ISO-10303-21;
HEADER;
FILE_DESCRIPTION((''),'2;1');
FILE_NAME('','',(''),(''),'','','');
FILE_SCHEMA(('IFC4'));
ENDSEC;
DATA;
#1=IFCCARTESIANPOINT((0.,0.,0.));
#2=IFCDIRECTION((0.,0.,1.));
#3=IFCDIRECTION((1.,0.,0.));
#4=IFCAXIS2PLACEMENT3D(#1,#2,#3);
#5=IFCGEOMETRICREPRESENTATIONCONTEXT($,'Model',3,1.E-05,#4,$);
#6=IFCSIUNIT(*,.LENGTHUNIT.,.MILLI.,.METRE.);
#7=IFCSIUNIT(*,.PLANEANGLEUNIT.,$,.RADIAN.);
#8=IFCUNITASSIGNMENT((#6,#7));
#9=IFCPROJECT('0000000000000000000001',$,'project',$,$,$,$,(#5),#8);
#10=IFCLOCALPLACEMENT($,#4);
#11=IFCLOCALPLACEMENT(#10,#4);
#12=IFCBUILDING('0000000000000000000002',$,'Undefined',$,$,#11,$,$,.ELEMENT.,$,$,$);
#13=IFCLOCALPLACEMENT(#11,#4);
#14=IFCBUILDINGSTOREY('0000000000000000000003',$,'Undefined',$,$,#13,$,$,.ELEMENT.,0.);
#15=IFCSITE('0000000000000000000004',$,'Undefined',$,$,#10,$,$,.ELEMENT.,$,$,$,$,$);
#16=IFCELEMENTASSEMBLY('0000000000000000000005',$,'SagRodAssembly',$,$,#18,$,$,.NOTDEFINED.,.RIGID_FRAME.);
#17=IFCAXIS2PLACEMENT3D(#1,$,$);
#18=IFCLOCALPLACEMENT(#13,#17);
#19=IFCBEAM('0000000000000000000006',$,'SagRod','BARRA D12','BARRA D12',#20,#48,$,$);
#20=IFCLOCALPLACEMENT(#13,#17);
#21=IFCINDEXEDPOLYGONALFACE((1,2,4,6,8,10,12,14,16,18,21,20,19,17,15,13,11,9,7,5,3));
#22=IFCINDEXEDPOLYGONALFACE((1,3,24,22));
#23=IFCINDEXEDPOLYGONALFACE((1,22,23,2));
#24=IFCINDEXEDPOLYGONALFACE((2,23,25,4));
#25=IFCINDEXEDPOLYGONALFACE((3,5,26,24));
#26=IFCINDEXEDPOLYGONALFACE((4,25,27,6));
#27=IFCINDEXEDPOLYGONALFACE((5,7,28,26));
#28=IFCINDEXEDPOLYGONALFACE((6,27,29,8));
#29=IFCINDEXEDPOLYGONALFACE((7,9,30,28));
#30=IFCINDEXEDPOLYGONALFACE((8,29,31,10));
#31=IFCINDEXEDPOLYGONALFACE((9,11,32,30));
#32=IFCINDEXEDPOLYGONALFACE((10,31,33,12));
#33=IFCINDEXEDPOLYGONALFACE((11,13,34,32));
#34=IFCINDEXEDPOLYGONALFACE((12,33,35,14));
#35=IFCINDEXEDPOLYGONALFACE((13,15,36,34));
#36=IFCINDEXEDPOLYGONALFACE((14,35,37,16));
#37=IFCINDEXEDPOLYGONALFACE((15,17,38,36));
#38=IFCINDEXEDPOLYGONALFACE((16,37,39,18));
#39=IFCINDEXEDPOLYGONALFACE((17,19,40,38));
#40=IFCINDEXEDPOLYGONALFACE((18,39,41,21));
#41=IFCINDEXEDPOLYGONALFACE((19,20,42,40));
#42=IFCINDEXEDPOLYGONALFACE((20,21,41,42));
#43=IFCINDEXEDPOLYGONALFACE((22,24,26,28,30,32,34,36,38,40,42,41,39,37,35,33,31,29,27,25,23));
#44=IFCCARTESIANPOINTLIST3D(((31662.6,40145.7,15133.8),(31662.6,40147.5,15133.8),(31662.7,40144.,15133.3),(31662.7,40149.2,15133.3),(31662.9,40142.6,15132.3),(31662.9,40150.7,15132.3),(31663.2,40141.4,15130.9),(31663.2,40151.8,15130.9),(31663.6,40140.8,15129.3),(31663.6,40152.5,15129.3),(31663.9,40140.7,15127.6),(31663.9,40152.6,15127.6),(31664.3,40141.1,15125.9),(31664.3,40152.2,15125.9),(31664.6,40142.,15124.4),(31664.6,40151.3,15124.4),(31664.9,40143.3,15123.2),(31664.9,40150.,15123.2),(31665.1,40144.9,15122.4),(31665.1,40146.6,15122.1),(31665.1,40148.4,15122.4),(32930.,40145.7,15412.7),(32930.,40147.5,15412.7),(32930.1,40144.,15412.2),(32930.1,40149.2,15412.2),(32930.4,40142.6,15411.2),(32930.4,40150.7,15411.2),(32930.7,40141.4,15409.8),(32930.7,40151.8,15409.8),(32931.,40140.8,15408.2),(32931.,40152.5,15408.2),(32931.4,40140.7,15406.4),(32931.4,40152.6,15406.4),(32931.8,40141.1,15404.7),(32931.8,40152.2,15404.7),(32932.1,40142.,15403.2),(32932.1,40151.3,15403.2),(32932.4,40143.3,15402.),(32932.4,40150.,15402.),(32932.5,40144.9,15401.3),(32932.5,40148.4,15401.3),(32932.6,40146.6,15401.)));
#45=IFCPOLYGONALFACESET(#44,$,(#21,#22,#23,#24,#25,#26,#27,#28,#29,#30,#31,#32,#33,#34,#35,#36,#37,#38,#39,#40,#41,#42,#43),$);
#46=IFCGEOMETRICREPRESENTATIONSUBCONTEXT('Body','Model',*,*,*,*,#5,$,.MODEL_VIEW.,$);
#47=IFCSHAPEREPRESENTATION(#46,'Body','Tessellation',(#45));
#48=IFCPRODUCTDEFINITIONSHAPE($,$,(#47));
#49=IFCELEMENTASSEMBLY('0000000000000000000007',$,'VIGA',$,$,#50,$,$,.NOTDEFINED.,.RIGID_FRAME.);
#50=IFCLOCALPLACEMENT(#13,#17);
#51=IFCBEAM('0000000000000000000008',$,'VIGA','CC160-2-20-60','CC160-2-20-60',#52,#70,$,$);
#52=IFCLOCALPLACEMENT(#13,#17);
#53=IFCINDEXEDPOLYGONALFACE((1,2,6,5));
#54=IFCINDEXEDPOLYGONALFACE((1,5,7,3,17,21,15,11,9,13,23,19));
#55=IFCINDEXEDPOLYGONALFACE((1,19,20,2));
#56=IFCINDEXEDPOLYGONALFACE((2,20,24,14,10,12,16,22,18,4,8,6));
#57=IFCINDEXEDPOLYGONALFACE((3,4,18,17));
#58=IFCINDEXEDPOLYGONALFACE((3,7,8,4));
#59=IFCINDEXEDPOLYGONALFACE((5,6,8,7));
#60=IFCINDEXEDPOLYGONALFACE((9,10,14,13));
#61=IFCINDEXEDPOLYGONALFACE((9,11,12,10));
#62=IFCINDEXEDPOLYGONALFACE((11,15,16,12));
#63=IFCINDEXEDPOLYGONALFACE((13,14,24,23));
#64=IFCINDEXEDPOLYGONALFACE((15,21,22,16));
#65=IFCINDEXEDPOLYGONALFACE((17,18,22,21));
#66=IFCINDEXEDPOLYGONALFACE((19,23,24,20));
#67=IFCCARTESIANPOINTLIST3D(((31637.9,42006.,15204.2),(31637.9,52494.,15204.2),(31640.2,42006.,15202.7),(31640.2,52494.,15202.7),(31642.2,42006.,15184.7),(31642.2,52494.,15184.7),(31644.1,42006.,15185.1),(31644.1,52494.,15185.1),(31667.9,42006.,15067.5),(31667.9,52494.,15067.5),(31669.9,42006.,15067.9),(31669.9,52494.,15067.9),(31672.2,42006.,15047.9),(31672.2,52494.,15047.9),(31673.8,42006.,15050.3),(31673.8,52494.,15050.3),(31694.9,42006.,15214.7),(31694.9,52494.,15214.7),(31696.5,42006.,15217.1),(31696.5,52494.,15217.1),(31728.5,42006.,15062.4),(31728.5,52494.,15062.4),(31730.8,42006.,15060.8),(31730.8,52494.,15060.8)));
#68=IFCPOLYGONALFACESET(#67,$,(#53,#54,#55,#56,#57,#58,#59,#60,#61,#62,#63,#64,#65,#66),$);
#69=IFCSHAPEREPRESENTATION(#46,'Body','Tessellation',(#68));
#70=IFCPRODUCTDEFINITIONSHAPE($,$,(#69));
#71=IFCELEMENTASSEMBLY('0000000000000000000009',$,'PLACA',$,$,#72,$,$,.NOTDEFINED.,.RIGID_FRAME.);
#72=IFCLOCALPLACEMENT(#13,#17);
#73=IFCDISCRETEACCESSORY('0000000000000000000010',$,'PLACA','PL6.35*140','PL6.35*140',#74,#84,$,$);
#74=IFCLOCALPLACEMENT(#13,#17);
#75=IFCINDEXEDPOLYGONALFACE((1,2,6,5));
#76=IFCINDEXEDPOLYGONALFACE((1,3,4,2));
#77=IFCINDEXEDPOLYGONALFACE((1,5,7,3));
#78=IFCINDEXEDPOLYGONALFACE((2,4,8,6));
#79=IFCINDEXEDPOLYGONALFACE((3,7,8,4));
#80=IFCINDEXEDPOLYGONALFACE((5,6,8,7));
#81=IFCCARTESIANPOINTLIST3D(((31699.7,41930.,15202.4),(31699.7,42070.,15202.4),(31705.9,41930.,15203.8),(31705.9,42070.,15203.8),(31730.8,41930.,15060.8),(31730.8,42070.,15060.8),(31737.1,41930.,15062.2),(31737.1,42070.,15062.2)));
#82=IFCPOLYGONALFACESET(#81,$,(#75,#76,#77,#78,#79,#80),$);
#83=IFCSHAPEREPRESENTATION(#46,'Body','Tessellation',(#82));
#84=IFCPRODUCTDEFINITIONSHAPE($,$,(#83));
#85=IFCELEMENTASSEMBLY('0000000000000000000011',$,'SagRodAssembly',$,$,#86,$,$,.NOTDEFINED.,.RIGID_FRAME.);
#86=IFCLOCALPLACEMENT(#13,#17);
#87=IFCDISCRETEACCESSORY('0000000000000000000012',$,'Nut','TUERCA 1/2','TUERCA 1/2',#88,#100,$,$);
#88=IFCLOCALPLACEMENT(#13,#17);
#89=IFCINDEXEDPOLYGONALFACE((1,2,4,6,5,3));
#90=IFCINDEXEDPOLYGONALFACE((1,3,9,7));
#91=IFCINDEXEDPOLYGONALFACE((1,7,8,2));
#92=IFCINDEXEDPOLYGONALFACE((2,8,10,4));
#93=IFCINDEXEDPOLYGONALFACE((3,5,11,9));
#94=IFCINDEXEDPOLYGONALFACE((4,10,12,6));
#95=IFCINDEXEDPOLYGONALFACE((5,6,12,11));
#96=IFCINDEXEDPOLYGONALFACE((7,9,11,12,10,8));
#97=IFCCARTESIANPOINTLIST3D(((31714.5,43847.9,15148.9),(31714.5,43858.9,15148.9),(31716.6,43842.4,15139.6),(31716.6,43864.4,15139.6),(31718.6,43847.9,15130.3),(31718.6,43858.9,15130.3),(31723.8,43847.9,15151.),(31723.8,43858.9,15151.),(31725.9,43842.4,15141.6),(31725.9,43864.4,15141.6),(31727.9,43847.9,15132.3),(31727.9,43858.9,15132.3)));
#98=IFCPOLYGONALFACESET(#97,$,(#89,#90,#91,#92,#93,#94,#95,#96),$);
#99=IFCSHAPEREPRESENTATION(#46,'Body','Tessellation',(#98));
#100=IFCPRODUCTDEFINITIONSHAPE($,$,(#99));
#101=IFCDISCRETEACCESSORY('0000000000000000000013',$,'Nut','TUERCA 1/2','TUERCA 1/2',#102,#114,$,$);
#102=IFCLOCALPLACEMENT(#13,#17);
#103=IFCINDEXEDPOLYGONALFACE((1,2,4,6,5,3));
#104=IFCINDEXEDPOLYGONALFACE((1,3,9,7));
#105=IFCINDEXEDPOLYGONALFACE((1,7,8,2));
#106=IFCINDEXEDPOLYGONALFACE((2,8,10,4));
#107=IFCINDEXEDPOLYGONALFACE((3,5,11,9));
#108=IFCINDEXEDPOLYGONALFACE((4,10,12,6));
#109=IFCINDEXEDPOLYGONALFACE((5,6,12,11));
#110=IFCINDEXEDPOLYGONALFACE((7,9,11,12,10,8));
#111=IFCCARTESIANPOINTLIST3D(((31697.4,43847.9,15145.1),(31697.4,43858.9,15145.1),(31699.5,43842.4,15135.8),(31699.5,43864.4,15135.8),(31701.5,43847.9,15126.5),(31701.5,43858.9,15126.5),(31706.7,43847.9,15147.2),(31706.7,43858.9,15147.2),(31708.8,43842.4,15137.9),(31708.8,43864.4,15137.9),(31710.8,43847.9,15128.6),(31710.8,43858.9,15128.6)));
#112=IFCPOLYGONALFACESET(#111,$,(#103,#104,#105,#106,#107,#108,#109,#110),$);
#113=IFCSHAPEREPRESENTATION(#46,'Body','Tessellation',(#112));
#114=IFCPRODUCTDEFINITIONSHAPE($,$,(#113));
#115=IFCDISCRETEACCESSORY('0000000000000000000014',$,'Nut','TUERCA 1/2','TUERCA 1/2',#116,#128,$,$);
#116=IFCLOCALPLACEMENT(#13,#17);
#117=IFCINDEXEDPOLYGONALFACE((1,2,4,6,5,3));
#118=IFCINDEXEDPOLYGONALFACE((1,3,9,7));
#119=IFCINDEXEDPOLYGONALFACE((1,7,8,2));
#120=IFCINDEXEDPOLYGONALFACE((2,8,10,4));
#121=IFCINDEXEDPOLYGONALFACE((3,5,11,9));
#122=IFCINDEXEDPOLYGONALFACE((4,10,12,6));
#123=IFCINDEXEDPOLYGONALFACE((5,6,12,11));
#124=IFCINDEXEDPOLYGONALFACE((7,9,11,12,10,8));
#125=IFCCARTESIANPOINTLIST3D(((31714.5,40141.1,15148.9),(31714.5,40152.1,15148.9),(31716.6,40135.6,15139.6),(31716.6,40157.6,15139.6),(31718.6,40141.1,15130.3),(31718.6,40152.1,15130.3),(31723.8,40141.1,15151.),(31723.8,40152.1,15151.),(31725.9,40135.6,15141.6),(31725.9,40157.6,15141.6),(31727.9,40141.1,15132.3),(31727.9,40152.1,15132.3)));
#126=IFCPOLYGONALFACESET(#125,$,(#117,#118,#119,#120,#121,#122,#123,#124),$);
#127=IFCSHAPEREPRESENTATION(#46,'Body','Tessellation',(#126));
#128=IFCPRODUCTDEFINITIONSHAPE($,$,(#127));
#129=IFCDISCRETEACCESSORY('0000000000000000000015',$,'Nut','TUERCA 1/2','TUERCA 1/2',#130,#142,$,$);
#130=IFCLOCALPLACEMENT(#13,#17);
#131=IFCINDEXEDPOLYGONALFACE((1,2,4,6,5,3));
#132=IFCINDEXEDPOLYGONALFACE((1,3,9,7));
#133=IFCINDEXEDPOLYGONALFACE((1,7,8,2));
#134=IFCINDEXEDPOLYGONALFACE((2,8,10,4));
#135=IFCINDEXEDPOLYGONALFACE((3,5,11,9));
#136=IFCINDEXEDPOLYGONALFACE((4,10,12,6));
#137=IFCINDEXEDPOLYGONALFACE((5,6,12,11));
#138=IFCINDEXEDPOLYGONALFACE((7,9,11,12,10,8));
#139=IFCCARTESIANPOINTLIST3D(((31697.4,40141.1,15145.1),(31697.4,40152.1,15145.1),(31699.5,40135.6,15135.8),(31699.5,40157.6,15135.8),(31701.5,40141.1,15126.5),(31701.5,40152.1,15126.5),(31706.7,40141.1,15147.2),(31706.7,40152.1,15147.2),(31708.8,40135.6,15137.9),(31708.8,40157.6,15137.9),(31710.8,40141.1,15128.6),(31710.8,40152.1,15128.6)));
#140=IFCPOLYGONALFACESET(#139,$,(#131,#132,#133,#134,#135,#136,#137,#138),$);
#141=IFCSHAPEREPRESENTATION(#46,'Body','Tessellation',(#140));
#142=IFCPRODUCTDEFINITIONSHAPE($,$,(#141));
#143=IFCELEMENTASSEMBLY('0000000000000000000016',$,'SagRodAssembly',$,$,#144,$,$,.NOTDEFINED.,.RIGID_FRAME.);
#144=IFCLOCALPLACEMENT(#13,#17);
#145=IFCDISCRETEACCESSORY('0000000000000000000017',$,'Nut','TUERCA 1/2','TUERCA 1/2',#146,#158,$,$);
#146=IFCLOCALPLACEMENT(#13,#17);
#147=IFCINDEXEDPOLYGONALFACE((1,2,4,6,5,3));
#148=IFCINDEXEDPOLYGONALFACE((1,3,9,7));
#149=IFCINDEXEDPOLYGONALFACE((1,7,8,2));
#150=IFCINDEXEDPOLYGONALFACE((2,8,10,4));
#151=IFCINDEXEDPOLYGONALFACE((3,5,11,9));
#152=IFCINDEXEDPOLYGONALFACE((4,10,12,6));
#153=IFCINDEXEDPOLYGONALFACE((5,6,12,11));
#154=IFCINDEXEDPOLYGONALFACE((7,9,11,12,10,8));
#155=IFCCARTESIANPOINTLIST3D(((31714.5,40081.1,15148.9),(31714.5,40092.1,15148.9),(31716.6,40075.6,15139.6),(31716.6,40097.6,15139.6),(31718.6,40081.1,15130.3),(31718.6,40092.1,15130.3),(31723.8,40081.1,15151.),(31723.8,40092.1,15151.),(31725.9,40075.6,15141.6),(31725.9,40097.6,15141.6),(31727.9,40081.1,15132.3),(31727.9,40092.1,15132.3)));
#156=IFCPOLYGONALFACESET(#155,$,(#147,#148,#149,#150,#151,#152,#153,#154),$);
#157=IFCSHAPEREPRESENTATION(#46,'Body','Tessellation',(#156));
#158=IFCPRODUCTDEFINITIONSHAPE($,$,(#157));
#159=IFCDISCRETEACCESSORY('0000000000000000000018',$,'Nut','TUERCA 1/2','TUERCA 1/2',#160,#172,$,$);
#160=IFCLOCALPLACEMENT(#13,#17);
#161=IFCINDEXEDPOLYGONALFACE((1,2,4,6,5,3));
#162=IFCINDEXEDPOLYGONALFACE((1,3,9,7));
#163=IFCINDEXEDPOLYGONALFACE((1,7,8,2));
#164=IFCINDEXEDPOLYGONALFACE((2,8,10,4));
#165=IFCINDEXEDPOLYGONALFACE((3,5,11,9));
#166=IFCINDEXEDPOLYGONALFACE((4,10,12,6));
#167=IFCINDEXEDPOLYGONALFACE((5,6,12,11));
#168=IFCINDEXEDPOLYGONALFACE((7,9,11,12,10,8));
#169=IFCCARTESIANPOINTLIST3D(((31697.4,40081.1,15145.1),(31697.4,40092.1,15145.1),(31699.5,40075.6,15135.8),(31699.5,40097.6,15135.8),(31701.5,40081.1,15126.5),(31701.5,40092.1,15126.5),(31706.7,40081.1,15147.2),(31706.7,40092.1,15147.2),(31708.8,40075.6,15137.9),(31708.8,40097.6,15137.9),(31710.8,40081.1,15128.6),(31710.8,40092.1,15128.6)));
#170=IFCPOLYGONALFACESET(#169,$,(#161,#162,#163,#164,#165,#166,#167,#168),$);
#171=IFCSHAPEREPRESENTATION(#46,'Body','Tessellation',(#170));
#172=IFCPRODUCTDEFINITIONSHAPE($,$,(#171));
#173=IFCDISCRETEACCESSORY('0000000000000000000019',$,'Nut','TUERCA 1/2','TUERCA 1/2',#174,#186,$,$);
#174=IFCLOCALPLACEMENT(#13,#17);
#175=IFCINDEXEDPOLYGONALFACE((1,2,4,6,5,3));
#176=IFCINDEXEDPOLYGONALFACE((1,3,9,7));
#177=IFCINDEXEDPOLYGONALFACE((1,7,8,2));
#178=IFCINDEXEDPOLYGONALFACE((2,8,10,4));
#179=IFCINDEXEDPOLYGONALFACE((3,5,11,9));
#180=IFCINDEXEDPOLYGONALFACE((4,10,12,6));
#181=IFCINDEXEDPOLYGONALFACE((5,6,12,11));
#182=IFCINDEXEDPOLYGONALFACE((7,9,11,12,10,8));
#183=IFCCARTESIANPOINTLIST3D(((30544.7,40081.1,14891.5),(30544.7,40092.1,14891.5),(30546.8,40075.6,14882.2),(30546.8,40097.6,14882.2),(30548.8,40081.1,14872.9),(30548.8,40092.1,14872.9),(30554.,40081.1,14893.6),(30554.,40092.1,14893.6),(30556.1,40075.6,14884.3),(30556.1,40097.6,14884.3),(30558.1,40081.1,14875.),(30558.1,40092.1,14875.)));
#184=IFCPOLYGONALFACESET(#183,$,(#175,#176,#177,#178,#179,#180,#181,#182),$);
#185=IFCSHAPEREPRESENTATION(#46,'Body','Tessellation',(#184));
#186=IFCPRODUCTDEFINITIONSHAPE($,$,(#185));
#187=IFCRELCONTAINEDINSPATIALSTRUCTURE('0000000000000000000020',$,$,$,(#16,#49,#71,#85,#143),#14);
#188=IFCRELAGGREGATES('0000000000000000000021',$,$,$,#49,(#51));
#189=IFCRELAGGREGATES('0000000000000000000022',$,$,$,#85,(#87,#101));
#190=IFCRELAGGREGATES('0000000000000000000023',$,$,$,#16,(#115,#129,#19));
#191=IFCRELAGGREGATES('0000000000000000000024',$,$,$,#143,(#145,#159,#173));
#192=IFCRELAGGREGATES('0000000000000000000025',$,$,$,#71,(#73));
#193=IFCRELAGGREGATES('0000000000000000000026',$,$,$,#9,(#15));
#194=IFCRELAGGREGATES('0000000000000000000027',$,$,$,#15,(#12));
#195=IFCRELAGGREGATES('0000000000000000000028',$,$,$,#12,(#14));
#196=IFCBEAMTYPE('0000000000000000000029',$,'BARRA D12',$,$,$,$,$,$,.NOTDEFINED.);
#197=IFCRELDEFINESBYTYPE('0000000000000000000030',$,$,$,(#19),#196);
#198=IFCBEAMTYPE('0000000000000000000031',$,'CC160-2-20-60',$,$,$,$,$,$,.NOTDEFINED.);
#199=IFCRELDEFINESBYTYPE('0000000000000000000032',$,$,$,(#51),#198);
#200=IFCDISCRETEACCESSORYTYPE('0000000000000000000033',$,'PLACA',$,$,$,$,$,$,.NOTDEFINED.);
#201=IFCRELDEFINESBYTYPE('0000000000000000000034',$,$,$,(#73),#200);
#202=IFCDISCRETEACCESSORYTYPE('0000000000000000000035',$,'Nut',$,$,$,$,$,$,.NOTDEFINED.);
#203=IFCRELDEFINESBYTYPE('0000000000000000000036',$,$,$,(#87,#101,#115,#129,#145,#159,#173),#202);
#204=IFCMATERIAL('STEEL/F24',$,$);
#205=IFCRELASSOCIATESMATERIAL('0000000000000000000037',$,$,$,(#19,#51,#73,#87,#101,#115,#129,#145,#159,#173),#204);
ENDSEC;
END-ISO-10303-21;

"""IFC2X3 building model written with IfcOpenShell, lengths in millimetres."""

from ifc_helpers import new_model, si_unit, frame, origin_with_axes, origin_2d_with_axis, place, context, subcontext, project, spatial, polyline, circle, c_section, outline, extrude, clip, halfspace, material, type_object, element, aggregate, save


model = new_model("IFC2X3")

# Units and contexts
model_context = context("Model", 3, precision=1e-05, world=origin_with_axes())
body_context = subcontext(model_context, "Body", "Model", "MODEL_VIEW")
ifc_project = project(units=[si_unit("LENGTHUNIT", "METRE", prefix="MILLI"), si_unit("PLANEANGLEUNIT", "RADIAN")], contexts=[model_context])

# Site, building, storey
site_placement = place(None, origin_with_axes())
site = spatial("IfcSite", under=ifc_project, at=site_placement, Name="Undefined", CompositionType="ELEMENT")
building_placement = place(site_placement, origin_with_axes())
building = spatial("IfcBuilding", under=site, at=building_placement, Name="Undefined", CompositionType="ELEMENT")
storey_placement = place(building_placement, origin_with_axes())
storey = spatial("IfcBuildingStorey", under=building, at=storey_placement, Name="Undefined", CompositionType="ELEMENT", Elevation=0.0)

# Element assemblies, beams
assembly_1_placement = place(storey_placement, origin_with_axes())
assembly_1 = element("IfcElementAssembly", 1, at=assembly_1_placement, inside=storey, Name="SagRodAssembly", AssemblyPlace="NOTDEFINED", PredefinedType="RIGID_FRAME")
ifc_material_1 = material(Name="STEEL/F24")
beam_type_1 = type_object("IfcBeamType", Name="BARRA D12", PredefinedType="NOTDEFINED")
beam_1_placement = place(assembly_1_placement, frame((31663.8, 40146.6, 15128.0), z_axis=(0.0, -1.0, 0.0), x_axis=(0.976639, 0.0, 0.214887)))
beam_1 = element("IfcBeam", 2, at=beam_1_placement, type_object=beam_type_1, material=ifc_material_1, Name="SagRod", Description="BARRA D12", ObjectType="BARRA D12", context=body_context, shape_type="SweptSolid", body=[
    extrude(circle(Radius=6.0, at=origin_2d_with_axis()), frame((1297.8, 0.0, 0.0), z_axis=(-1.0, 0.0, 0.0), x_axis=(0.0, -1.0, 0.0)), (0.0, 0.0, 1.0), 1297.8),
])
assembly_2_placement = place(storey_placement, origin_with_axes())
assembly_2 = element("IfcElementAssembly", 3, at=assembly_2_placement, inside=storey, Name="VIGA", AssemblyPlace="NOTDEFINED", PredefinedType="RIGID_FRAME")
beam_type_2 = type_object("IfcBeamType", Name="CC160-2-20-60", PredefinedType="NOTDEFINED")
beam_2_placement = place(assembly_2_placement, frame((31684.4, 42000.0, 15132.5), z_axis=(0.214887, 0.0, -0.976639), x_axis=(0.0, 1.0, 0.0)))
beam_2 = element("IfcBeam", 4, at=beam_2_placement, type_object=beam_type_2, material=ifc_material_1, Name="VIGA", Description="CC160-2-20-60", ObjectType="CC160-2-20-60", context=body_context, shape_type="Clipping", body=[
    clip(clip(extrude(c_section(Depth=160.0, Width=60.0, WallThickness=2.0, Girth=20.0, at=origin_2d_with_axis()), frame((10500.0, 0.0, 0.0), z_axis=(-1.0, 0.0, 0.0), x_axis=(0.0, -1.0, 0.0)), (0.0, 0.0, 1.0), 10500.0), halfspace(frame((10494.0, -30.0, -80.0), z_axis=(1.0, 0.0, 0.000029), x_axis=(-0.000029, 0.0, 1.0)), False)), halfspace(frame((6.0, 30.0, -80.0), z_axis=(-1.0, 0.0, -0.000029), x_axis=(-0.000029, 0.0, 1.0)), False)),
])
aggregate(assembly_2, [beam_2])

# Element assembly, discrete accessory
assembly_3_placement = place(storey_placement, origin_with_axes())
assembly_3 = element("IfcElementAssembly", 5, at=assembly_3_placement, inside=storey, Name="PLACA", AssemblyPlace="NOTDEFINED", PredefinedType="RIGID_FRAME")
discrete_accessory_type_1 = type_object("IfcDiscreteAccessoryType", Name="PLACA")
discrete_accessory_1_placement = place(assembly_3_placement, frame((31702.8, 41930.0, 15203.1), z_axis=(-0.976639, 0.0, -0.214887), x_axis=(0.0, 1.0, 0.0)))
discrete_accessory_1 = element("IfcDiscreteAccessory", 6, at=discrete_accessory_1_placement, type_object=discrete_accessory_type_1, material=ifc_material_1, Name="PLACA", Description="PL6.35*140", ObjectType="PL6.35*140", context=body_context, shape_type="SweptSolid", body=[
    extrude(outline(polyline([(0.0, 0.0), (140.0, 0.0), (140.0, 145.0), (0.0, 145.0), (0.0, 0.0)])), frame((0.0, 0.0, -3.2), z_axis=(0.0, 0.0, 1.0), x_axis=(1.0, 0.0, 0.0)), (0.0, 0.0, 1.0), 6.4),
])

# Element assembly, discrete accessories
assembly_4_placement = place(storey_placement, origin_with_axes())
assembly_4 = element("IfcElementAssembly", 7, at=assembly_4_placement, inside=storey, Name="SagRodAssembly", AssemblyPlace="NOTDEFINED", PredefinedType="RIGID_FRAME")
discrete_accessory_type_2 = type_object("IfcDiscreteAccessoryType", Name="Nut")
discrete_accessory_2_placement = place(assembly_4_placement, frame((31716.6, 43853.4, 15139.6), z_axis=(-0.214887, 0.0, 0.976639), x_axis=(0.976639, 0.0, 0.214887)))
discrete_accessory_2 = element("IfcDiscreteAccessory", 8, at=discrete_accessory_2_placement, type_object=discrete_accessory_type_2, material=ifc_material_1, Name="Nut", Description="TUERCA 1/2", ObjectType="TUERCA 1/2", context=body_context, shape_type="SweptSolid", body=[
    extrude(outline(polyline([(-5.5, 9.5), (5.5, 9.5), (11.0, 0.0), (5.5, -9.5), (-5.5, -9.5), (-11.0, 0.0), (-5.5, 9.5)])), frame((9.5, 0.0, 0.0), z_axis=(-1.0, 0.0, 0.0), x_axis=(0.0, -1.0, 0.0)), (0.0, 0.0, 1.0), 9.5),
])
discrete_accessory_3_placement = place(assembly_4_placement, frame((31699.5, 43853.4, 15135.8), z_axis=(-0.214887, 0.0, 0.976639), x_axis=(0.976639, 0.0, 0.214887)))
discrete_accessory_3 = element("IfcDiscreteAccessory", 9, at=discrete_accessory_3_placement, type_object=discrete_accessory_type_2, material=ifc_material_1, Name="Nut", Description="TUERCA 1/2", ObjectType="TUERCA 1/2", context=body_context, shape_type="SweptSolid", body=[
    extrude(outline(polyline([(-5.5, 9.5), (5.5, 9.5), (11.0, 0.0), (5.5, -9.5), (-5.5, -9.5), (-11.0, 0.0), (-5.5, 9.5)])), frame((9.5, 0.0, 0.0), z_axis=(-1.0, 0.0, 0.0), x_axis=(0.0, -1.0, 0.0)), (0.0, 0.0, 1.0), 9.5),
])

# Discrete accessories
discrete_accessory_4_placement = place(assembly_1_placement, frame((31716.6, 40146.6, 15139.6), z_axis=(-0.214887, 0.0, 0.976639), x_axis=(0.976639, 0.0, 0.214887)))
discrete_accessory_4 = element("IfcDiscreteAccessory", 10, at=discrete_accessory_4_placement, type_object=discrete_accessory_type_2, material=ifc_material_1, Name="Nut", Description="TUERCA 1/2", ObjectType="TUERCA 1/2", context=body_context, shape_type="SweptSolid", body=[
    extrude(outline(polyline([(-5.5, 9.5), (5.5, 9.5), (11.0, 0.0), (5.5, -9.5), (-5.5, -9.5), (-11.0, 0.0), (-5.5, 9.5)])), frame((9.5, 0.0, 0.0), z_axis=(-1.0, 0.0, 0.0), x_axis=(0.0, -1.0, 0.0)), (0.0, 0.0, 1.0), 9.5),
])
discrete_accessory_5_placement = place(assembly_1_placement, frame((31699.5, 40146.6, 15135.8), z_axis=(-0.214887, 0.0, 0.976639), x_axis=(0.976639, 0.0, 0.214887)))
discrete_accessory_5 = element("IfcDiscreteAccessory", 11, at=discrete_accessory_5_placement, type_object=discrete_accessory_type_2, material=ifc_material_1, Name="Nut", Description="TUERCA 1/2", ObjectType="TUERCA 1/2", context=body_context, shape_type="SweptSolid", body=[
    extrude(outline(polyline([(-5.5, 9.5), (5.5, 9.5), (11.0, 0.0), (5.5, -9.5), (-5.5, -9.5), (-11.0, 0.0), (-5.5, 9.5)])), frame((9.5, 0.0, 0.0), z_axis=(-1.0, 0.0, 0.0), x_axis=(0.0, -1.0, 0.0)), (0.0, 0.0, 1.0), 9.5),
])

# Element assembly, discrete accessories
assembly_5_placement = place(storey_placement, origin_with_axes())
assembly_5 = element("IfcElementAssembly", 12, at=assembly_5_placement, inside=storey, Name="SagRodAssembly", AssemblyPlace="NOTDEFINED", PredefinedType="RIGID_FRAME")
discrete_accessory_6_placement = place(assembly_5_placement, frame((31716.6, 40086.6, 15139.6), z_axis=(-0.214887, 0.0, 0.976639), x_axis=(0.976639, 0.0, 0.214887)))
discrete_accessory_6 = element("IfcDiscreteAccessory", 13, at=discrete_accessory_6_placement, type_object=discrete_accessory_type_2, material=ifc_material_1, Name="Nut", Description="TUERCA 1/2", ObjectType="TUERCA 1/2", context=body_context, shape_type="SweptSolid", body=[
    extrude(outline(polyline([(-5.5, 9.5), (5.5, 9.5), (11.0, 0.0), (5.5, -9.5), (-5.5, -9.5), (-11.0, 0.0), (-5.5, 9.5)])), frame((9.5, 0.0, 0.0), z_axis=(-1.0, 0.0, 0.0), x_axis=(0.0, -1.0, 0.0)), (0.0, 0.0, 1.0), 9.5),
])
discrete_accessory_7_placement = place(assembly_5_placement, frame((31699.5, 40086.6, 15135.8), z_axis=(-0.214887, 0.0, 0.976639), x_axis=(0.976639, 0.0, 0.214887)))
discrete_accessory_7 = element("IfcDiscreteAccessory", 14, at=discrete_accessory_7_placement, type_object=discrete_accessory_type_2, material=ifc_material_1, Name="Nut", Description="TUERCA 1/2", ObjectType="TUERCA 1/2", context=body_context, shape_type="SweptSolid", body=[
    extrude(outline(polyline([(-5.5, 9.5), (5.5, 9.5), (11.0, 0.0), (5.5, -9.5), (-5.5, -9.5), (-11.0, 0.0), (-5.5, 9.5)])), frame((9.5, 0.0, 0.0), z_axis=(-1.0, 0.0, 0.0), x_axis=(0.0, -1.0, 0.0)), (0.0, 0.0, 1.0), 9.5),
])
discrete_accessory_8_placement = place(assembly_5_placement, frame((30546.8, 40086.6, 14882.2), z_axis=(-0.214887, 0.0, 0.976639), x_axis=(0.976639, 0.0, 0.214887)))
discrete_accessory_8 = element("IfcDiscreteAccessory", 15, at=discrete_accessory_8_placement, type_object=discrete_accessory_type_2, material=ifc_material_1, Name="Nut", Description="TUERCA 1/2", ObjectType="TUERCA 1/2", context=body_context, shape_type="SweptSolid", body=[
    extrude(outline(polyline([(-5.5, 9.5), (5.5, 9.5), (11.0, 0.0), (5.5, -9.5), (-5.5, -9.5), (-11.0, 0.0), (-5.5, 9.5)])), frame((9.5, 0.0, 0.0), z_axis=(-1.0, 0.0, 0.0), x_axis=(0.0, -1.0, 0.0)), (0.0, 0.0, 1.0), 9.5),
])

aggregate(assembly_4, [discrete_accessory_2, discrete_accessory_3])
aggregate(assembly_1, [discrete_accessory_4, discrete_accessory_5, beam_1])
aggregate(assembly_5, [discrete_accessory_6, discrete_accessory_7, discrete_accessory_8])

aggregate(assembly_3, [discrete_accessory_1])

save(model, "model.ifc")
